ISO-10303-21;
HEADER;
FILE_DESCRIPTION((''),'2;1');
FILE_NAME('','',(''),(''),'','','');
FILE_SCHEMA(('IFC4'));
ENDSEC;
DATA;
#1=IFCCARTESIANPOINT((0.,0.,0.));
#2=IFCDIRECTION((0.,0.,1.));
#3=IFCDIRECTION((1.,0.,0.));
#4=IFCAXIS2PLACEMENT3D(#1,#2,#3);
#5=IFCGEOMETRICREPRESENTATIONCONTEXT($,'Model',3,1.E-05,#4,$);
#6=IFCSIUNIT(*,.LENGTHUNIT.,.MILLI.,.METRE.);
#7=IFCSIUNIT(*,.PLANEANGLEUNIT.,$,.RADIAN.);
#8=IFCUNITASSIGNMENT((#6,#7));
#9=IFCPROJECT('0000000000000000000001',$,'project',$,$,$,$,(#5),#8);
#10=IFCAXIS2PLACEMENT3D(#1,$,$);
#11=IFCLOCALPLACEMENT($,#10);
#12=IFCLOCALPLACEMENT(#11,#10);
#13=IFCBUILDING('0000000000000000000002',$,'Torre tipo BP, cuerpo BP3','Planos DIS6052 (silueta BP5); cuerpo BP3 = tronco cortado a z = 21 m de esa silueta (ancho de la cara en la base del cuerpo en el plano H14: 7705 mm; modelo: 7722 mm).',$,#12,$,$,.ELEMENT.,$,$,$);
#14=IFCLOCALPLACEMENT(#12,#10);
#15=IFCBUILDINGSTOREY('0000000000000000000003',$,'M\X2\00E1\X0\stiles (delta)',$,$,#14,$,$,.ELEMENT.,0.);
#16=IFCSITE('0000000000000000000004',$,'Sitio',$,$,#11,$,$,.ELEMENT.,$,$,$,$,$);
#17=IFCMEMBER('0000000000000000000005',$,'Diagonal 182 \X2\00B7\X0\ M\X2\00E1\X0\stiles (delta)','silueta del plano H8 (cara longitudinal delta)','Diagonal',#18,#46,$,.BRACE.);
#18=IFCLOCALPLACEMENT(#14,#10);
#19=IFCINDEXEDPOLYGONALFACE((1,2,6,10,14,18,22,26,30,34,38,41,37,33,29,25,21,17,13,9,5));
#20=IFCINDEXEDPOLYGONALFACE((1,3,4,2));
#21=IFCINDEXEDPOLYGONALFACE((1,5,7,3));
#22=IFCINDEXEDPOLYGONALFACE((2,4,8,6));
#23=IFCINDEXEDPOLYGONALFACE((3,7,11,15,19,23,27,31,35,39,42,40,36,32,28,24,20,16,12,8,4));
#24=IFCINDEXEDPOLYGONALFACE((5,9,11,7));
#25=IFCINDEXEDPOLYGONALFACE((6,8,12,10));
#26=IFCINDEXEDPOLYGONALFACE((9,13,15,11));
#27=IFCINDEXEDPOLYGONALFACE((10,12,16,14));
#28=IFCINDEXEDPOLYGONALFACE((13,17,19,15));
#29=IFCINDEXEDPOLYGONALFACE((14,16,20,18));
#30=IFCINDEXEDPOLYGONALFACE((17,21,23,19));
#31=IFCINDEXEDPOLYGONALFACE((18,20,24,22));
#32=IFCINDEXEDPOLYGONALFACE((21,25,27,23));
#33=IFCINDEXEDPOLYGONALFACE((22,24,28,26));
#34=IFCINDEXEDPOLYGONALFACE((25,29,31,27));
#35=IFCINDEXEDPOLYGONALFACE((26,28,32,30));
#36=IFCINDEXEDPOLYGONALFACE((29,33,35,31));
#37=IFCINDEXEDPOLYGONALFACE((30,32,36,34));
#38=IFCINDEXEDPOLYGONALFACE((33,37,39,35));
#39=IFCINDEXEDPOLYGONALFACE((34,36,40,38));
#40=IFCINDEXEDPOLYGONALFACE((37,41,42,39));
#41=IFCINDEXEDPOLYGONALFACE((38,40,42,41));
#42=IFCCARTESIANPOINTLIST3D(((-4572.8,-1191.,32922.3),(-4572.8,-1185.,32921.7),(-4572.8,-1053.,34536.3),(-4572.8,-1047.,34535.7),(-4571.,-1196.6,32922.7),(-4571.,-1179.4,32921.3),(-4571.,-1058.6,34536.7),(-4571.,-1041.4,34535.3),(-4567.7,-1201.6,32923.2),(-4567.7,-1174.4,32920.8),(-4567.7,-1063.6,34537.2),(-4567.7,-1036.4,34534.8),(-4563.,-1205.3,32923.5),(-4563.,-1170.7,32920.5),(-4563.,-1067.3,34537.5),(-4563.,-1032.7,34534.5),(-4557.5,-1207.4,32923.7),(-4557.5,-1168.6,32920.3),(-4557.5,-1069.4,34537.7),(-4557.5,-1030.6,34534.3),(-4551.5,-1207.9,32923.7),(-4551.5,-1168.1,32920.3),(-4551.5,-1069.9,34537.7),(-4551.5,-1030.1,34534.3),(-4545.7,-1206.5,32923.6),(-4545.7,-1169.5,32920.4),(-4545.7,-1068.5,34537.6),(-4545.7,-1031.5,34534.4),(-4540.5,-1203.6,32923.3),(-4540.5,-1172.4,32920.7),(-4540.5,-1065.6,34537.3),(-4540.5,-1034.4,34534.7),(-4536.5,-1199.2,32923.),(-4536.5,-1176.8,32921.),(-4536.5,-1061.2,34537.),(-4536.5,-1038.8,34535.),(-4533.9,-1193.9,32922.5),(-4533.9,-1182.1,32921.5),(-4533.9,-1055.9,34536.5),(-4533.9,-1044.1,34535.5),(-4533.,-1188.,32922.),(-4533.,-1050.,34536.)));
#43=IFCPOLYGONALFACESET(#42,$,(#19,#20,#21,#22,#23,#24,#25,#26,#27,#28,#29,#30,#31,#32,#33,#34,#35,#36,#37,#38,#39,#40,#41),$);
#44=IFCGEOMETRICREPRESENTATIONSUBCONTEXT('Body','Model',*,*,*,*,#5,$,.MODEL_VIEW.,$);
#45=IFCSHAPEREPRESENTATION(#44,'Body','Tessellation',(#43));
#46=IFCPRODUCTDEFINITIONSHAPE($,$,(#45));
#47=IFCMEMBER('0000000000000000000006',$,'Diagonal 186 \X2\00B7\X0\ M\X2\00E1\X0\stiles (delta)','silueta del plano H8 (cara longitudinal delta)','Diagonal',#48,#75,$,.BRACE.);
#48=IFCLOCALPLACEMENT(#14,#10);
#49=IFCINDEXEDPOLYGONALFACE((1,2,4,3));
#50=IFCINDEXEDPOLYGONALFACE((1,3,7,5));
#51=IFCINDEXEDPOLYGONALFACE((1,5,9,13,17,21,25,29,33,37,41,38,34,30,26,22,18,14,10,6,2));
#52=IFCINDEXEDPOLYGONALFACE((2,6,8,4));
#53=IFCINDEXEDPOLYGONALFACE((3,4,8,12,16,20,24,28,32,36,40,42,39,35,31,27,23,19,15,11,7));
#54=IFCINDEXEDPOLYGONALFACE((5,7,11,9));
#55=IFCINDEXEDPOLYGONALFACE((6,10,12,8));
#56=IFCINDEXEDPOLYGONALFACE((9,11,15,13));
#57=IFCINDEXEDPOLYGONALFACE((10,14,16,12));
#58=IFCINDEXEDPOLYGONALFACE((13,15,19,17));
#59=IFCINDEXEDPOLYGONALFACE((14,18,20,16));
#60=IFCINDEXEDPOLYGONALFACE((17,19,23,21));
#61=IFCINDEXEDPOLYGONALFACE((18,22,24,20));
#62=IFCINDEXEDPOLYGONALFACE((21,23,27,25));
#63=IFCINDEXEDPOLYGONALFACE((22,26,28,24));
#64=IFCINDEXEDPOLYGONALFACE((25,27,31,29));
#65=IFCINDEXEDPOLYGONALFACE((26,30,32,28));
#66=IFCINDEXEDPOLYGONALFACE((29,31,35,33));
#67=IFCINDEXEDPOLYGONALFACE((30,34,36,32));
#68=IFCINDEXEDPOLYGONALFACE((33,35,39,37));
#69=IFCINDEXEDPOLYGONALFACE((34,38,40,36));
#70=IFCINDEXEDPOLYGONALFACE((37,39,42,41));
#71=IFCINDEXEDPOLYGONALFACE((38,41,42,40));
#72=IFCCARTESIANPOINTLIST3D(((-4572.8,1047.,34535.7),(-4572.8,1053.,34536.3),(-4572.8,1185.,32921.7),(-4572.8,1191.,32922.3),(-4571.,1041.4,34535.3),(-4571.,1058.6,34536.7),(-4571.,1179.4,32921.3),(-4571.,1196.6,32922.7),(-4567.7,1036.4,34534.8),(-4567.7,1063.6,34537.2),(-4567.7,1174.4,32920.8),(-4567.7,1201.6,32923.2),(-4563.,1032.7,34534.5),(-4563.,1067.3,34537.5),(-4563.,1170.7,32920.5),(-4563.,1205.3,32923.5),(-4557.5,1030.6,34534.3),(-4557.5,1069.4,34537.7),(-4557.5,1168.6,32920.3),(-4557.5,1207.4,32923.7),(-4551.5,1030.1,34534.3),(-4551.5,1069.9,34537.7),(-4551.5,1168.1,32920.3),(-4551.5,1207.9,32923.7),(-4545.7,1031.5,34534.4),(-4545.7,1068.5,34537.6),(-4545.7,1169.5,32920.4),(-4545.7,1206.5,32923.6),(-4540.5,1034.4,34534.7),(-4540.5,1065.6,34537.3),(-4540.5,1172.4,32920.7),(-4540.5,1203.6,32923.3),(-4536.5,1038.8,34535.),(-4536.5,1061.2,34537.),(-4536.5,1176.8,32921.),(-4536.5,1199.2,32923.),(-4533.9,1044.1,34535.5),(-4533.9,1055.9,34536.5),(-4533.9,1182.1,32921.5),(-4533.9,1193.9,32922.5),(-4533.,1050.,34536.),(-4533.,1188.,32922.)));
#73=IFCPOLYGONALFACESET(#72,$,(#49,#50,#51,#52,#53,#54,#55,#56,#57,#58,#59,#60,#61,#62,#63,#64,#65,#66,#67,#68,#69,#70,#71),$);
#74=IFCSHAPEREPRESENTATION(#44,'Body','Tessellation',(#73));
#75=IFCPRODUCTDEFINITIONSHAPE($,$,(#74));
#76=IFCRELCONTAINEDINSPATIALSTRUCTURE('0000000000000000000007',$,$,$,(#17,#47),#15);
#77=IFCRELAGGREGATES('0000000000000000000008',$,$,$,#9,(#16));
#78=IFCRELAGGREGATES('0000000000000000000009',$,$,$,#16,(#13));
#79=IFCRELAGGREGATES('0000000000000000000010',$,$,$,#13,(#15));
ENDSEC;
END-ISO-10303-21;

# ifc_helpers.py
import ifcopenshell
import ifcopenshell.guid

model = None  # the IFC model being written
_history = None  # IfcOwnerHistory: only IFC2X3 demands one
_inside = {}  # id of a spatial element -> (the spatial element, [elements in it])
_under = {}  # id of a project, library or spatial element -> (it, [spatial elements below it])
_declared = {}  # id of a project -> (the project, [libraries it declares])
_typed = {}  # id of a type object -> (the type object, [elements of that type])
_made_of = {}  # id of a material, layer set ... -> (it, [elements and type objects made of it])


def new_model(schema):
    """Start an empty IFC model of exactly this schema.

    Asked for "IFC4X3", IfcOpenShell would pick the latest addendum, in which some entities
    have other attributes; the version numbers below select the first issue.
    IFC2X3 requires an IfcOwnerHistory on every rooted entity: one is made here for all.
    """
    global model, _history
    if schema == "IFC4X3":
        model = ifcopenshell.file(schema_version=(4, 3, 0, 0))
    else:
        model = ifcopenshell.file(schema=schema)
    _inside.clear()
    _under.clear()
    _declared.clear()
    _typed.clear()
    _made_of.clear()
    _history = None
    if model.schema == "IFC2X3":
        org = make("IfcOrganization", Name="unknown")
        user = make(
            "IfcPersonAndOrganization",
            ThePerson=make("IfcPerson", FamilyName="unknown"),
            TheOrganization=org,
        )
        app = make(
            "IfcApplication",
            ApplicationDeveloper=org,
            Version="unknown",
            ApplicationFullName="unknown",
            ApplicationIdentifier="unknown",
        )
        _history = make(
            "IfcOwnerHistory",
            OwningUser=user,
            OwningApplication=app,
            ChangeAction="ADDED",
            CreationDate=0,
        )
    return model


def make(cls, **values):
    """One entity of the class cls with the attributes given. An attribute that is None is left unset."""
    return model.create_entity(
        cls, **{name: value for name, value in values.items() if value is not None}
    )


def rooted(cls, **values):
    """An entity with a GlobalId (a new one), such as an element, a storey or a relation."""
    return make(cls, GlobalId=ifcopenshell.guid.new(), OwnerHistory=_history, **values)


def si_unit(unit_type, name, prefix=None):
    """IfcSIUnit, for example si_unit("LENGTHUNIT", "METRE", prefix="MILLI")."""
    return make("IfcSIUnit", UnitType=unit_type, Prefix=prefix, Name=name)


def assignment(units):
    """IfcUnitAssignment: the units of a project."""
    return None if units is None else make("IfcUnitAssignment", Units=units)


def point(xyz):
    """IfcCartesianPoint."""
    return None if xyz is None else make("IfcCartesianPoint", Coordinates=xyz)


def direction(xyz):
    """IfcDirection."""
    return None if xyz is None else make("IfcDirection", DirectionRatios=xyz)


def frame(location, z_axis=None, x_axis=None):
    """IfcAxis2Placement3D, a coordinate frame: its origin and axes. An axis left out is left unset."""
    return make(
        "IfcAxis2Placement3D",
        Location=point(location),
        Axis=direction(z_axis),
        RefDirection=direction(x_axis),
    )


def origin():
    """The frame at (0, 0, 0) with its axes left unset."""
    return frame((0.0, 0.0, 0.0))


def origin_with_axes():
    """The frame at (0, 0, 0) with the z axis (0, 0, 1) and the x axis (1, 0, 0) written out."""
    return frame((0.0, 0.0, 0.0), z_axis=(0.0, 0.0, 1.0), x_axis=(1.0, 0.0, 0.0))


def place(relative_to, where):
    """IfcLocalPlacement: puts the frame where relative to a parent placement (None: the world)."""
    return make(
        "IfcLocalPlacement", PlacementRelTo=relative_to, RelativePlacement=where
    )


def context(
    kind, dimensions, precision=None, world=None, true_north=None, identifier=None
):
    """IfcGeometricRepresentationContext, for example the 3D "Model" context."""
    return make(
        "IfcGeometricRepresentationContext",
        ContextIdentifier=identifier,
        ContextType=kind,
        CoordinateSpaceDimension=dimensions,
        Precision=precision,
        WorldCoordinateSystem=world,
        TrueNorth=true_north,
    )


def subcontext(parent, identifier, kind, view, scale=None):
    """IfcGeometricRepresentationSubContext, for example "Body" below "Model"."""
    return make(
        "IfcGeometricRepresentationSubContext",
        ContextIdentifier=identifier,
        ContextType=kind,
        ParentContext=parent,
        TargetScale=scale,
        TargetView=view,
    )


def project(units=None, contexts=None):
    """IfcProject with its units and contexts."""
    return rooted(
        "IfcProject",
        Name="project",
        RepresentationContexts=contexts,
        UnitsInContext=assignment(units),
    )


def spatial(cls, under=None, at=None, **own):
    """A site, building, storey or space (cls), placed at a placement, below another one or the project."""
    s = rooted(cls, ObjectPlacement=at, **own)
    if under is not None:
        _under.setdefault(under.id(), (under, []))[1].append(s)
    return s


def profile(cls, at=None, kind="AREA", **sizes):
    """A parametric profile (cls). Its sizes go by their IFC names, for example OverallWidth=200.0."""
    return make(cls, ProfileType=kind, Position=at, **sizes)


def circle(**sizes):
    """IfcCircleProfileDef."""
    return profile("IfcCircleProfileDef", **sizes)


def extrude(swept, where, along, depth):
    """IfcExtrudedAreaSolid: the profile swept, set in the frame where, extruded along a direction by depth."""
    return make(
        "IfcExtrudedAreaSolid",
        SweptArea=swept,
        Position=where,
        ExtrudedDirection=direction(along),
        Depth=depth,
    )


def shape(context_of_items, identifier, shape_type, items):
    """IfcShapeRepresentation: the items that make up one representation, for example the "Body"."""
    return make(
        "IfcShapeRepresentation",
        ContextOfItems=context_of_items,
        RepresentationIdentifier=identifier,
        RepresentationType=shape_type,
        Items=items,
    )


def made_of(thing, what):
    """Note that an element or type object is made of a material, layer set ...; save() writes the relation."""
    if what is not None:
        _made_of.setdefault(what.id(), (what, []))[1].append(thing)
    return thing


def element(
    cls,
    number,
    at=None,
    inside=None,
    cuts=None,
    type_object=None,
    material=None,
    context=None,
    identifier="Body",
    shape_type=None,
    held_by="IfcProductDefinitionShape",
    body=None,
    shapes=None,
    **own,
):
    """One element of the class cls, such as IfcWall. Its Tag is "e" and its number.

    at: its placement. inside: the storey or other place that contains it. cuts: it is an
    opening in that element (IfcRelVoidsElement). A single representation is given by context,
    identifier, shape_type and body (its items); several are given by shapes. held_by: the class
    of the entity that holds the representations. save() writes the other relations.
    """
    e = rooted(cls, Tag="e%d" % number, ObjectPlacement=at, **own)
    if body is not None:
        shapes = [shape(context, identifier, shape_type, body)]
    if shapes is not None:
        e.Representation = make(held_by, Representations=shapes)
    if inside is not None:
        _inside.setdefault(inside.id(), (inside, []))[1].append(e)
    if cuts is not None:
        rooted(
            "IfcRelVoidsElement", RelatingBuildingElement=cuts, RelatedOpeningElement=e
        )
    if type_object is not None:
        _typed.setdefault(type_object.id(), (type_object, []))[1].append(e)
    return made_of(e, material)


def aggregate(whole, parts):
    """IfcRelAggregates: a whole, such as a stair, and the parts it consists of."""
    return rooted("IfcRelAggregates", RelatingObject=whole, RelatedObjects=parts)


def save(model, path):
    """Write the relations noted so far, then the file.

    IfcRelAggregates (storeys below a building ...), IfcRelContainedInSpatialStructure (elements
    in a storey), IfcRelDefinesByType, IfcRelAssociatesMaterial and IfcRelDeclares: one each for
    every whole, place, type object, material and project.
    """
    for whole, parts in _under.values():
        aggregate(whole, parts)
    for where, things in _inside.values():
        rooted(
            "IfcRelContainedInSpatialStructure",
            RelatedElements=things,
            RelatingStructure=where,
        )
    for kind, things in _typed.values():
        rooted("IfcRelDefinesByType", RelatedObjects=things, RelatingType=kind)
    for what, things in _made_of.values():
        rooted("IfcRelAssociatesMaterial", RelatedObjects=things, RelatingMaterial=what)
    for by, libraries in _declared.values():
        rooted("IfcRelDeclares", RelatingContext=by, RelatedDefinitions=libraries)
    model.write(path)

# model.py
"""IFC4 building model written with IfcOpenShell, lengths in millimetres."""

from ifc_helpers import new_model, si_unit, frame, origin, origin_with_axes, place, context, subcontext, project, spatial, circle, extrude, element, save


model = new_model("IFC4")

# Units and contexts
model_context = context("Model", 3, precision=1e-05, world=origin_with_axes())
body_context = subcontext(model_context, "Body", "Model", "MODEL_VIEW")
ifc_project = project(units=[si_unit("LENGTHUNIT", "METRE", prefix="MILLI"), si_unit("PLANEANGLEUNIT", "RADIAN")], contexts=[model_context])

# Site, building, storey
site_placement = place(None, origin())
site = spatial("IfcSite", under=ifc_project, at=site_placement, Name="Sitio", CompositionType="ELEMENT")
building_placement = place(site_placement, origin())
building = spatial("IfcBuilding", under=site, at=building_placement, Name="Torre tipo BP, cuerpo BP3", Description="Planos DIS6052 (silueta BP5); cuerpo BP3 = tronco cortado a z = 21 m de esa silueta (ancho de la cara en la base del cuerpo en el plano H14: 7705 mm; modelo: 7722 mm).", CompositionType="ELEMENT")
storey_placement = place(building_placement, origin())
storey = spatial("IfcBuildingStorey", under=building, at=storey_placement, Name="Mástiles (delta)", CompositionType="ELEMENT", Elevation=0.0)

# Members
for number, where, z_axis, x_axis, name in (
    (1, (-4553.0, -1050.0, 34536.0), (0.0, -0.085191, -0.996365), (1.0, 0.0, 0.0), "Diagonal 182 · Mástiles (delta)"),
    (2, (-4553.0, 1050.0, 34536.0), (0.0, 0.085191, -0.996365), (1.0, 0.0, 0.0), "Diagonal 186 · Mástiles (delta)"),
):
    element("IfcMember", number, at=place(storey_placement, frame(where, z_axis=z_axis, x_axis=x_axis)), inside=storey, Name=name, Description="silueta del plano H8 (cara longitudinal delta)", ObjectType="Diagonal", PredefinedType="BRACE", context=body_context, shape_type="SweptSolid", body=[
        extrude(circle(Radius=20.0), None, (0.0, 0.0, 1.0), 1619.9),
    ])

save(model, "model.ifc")
